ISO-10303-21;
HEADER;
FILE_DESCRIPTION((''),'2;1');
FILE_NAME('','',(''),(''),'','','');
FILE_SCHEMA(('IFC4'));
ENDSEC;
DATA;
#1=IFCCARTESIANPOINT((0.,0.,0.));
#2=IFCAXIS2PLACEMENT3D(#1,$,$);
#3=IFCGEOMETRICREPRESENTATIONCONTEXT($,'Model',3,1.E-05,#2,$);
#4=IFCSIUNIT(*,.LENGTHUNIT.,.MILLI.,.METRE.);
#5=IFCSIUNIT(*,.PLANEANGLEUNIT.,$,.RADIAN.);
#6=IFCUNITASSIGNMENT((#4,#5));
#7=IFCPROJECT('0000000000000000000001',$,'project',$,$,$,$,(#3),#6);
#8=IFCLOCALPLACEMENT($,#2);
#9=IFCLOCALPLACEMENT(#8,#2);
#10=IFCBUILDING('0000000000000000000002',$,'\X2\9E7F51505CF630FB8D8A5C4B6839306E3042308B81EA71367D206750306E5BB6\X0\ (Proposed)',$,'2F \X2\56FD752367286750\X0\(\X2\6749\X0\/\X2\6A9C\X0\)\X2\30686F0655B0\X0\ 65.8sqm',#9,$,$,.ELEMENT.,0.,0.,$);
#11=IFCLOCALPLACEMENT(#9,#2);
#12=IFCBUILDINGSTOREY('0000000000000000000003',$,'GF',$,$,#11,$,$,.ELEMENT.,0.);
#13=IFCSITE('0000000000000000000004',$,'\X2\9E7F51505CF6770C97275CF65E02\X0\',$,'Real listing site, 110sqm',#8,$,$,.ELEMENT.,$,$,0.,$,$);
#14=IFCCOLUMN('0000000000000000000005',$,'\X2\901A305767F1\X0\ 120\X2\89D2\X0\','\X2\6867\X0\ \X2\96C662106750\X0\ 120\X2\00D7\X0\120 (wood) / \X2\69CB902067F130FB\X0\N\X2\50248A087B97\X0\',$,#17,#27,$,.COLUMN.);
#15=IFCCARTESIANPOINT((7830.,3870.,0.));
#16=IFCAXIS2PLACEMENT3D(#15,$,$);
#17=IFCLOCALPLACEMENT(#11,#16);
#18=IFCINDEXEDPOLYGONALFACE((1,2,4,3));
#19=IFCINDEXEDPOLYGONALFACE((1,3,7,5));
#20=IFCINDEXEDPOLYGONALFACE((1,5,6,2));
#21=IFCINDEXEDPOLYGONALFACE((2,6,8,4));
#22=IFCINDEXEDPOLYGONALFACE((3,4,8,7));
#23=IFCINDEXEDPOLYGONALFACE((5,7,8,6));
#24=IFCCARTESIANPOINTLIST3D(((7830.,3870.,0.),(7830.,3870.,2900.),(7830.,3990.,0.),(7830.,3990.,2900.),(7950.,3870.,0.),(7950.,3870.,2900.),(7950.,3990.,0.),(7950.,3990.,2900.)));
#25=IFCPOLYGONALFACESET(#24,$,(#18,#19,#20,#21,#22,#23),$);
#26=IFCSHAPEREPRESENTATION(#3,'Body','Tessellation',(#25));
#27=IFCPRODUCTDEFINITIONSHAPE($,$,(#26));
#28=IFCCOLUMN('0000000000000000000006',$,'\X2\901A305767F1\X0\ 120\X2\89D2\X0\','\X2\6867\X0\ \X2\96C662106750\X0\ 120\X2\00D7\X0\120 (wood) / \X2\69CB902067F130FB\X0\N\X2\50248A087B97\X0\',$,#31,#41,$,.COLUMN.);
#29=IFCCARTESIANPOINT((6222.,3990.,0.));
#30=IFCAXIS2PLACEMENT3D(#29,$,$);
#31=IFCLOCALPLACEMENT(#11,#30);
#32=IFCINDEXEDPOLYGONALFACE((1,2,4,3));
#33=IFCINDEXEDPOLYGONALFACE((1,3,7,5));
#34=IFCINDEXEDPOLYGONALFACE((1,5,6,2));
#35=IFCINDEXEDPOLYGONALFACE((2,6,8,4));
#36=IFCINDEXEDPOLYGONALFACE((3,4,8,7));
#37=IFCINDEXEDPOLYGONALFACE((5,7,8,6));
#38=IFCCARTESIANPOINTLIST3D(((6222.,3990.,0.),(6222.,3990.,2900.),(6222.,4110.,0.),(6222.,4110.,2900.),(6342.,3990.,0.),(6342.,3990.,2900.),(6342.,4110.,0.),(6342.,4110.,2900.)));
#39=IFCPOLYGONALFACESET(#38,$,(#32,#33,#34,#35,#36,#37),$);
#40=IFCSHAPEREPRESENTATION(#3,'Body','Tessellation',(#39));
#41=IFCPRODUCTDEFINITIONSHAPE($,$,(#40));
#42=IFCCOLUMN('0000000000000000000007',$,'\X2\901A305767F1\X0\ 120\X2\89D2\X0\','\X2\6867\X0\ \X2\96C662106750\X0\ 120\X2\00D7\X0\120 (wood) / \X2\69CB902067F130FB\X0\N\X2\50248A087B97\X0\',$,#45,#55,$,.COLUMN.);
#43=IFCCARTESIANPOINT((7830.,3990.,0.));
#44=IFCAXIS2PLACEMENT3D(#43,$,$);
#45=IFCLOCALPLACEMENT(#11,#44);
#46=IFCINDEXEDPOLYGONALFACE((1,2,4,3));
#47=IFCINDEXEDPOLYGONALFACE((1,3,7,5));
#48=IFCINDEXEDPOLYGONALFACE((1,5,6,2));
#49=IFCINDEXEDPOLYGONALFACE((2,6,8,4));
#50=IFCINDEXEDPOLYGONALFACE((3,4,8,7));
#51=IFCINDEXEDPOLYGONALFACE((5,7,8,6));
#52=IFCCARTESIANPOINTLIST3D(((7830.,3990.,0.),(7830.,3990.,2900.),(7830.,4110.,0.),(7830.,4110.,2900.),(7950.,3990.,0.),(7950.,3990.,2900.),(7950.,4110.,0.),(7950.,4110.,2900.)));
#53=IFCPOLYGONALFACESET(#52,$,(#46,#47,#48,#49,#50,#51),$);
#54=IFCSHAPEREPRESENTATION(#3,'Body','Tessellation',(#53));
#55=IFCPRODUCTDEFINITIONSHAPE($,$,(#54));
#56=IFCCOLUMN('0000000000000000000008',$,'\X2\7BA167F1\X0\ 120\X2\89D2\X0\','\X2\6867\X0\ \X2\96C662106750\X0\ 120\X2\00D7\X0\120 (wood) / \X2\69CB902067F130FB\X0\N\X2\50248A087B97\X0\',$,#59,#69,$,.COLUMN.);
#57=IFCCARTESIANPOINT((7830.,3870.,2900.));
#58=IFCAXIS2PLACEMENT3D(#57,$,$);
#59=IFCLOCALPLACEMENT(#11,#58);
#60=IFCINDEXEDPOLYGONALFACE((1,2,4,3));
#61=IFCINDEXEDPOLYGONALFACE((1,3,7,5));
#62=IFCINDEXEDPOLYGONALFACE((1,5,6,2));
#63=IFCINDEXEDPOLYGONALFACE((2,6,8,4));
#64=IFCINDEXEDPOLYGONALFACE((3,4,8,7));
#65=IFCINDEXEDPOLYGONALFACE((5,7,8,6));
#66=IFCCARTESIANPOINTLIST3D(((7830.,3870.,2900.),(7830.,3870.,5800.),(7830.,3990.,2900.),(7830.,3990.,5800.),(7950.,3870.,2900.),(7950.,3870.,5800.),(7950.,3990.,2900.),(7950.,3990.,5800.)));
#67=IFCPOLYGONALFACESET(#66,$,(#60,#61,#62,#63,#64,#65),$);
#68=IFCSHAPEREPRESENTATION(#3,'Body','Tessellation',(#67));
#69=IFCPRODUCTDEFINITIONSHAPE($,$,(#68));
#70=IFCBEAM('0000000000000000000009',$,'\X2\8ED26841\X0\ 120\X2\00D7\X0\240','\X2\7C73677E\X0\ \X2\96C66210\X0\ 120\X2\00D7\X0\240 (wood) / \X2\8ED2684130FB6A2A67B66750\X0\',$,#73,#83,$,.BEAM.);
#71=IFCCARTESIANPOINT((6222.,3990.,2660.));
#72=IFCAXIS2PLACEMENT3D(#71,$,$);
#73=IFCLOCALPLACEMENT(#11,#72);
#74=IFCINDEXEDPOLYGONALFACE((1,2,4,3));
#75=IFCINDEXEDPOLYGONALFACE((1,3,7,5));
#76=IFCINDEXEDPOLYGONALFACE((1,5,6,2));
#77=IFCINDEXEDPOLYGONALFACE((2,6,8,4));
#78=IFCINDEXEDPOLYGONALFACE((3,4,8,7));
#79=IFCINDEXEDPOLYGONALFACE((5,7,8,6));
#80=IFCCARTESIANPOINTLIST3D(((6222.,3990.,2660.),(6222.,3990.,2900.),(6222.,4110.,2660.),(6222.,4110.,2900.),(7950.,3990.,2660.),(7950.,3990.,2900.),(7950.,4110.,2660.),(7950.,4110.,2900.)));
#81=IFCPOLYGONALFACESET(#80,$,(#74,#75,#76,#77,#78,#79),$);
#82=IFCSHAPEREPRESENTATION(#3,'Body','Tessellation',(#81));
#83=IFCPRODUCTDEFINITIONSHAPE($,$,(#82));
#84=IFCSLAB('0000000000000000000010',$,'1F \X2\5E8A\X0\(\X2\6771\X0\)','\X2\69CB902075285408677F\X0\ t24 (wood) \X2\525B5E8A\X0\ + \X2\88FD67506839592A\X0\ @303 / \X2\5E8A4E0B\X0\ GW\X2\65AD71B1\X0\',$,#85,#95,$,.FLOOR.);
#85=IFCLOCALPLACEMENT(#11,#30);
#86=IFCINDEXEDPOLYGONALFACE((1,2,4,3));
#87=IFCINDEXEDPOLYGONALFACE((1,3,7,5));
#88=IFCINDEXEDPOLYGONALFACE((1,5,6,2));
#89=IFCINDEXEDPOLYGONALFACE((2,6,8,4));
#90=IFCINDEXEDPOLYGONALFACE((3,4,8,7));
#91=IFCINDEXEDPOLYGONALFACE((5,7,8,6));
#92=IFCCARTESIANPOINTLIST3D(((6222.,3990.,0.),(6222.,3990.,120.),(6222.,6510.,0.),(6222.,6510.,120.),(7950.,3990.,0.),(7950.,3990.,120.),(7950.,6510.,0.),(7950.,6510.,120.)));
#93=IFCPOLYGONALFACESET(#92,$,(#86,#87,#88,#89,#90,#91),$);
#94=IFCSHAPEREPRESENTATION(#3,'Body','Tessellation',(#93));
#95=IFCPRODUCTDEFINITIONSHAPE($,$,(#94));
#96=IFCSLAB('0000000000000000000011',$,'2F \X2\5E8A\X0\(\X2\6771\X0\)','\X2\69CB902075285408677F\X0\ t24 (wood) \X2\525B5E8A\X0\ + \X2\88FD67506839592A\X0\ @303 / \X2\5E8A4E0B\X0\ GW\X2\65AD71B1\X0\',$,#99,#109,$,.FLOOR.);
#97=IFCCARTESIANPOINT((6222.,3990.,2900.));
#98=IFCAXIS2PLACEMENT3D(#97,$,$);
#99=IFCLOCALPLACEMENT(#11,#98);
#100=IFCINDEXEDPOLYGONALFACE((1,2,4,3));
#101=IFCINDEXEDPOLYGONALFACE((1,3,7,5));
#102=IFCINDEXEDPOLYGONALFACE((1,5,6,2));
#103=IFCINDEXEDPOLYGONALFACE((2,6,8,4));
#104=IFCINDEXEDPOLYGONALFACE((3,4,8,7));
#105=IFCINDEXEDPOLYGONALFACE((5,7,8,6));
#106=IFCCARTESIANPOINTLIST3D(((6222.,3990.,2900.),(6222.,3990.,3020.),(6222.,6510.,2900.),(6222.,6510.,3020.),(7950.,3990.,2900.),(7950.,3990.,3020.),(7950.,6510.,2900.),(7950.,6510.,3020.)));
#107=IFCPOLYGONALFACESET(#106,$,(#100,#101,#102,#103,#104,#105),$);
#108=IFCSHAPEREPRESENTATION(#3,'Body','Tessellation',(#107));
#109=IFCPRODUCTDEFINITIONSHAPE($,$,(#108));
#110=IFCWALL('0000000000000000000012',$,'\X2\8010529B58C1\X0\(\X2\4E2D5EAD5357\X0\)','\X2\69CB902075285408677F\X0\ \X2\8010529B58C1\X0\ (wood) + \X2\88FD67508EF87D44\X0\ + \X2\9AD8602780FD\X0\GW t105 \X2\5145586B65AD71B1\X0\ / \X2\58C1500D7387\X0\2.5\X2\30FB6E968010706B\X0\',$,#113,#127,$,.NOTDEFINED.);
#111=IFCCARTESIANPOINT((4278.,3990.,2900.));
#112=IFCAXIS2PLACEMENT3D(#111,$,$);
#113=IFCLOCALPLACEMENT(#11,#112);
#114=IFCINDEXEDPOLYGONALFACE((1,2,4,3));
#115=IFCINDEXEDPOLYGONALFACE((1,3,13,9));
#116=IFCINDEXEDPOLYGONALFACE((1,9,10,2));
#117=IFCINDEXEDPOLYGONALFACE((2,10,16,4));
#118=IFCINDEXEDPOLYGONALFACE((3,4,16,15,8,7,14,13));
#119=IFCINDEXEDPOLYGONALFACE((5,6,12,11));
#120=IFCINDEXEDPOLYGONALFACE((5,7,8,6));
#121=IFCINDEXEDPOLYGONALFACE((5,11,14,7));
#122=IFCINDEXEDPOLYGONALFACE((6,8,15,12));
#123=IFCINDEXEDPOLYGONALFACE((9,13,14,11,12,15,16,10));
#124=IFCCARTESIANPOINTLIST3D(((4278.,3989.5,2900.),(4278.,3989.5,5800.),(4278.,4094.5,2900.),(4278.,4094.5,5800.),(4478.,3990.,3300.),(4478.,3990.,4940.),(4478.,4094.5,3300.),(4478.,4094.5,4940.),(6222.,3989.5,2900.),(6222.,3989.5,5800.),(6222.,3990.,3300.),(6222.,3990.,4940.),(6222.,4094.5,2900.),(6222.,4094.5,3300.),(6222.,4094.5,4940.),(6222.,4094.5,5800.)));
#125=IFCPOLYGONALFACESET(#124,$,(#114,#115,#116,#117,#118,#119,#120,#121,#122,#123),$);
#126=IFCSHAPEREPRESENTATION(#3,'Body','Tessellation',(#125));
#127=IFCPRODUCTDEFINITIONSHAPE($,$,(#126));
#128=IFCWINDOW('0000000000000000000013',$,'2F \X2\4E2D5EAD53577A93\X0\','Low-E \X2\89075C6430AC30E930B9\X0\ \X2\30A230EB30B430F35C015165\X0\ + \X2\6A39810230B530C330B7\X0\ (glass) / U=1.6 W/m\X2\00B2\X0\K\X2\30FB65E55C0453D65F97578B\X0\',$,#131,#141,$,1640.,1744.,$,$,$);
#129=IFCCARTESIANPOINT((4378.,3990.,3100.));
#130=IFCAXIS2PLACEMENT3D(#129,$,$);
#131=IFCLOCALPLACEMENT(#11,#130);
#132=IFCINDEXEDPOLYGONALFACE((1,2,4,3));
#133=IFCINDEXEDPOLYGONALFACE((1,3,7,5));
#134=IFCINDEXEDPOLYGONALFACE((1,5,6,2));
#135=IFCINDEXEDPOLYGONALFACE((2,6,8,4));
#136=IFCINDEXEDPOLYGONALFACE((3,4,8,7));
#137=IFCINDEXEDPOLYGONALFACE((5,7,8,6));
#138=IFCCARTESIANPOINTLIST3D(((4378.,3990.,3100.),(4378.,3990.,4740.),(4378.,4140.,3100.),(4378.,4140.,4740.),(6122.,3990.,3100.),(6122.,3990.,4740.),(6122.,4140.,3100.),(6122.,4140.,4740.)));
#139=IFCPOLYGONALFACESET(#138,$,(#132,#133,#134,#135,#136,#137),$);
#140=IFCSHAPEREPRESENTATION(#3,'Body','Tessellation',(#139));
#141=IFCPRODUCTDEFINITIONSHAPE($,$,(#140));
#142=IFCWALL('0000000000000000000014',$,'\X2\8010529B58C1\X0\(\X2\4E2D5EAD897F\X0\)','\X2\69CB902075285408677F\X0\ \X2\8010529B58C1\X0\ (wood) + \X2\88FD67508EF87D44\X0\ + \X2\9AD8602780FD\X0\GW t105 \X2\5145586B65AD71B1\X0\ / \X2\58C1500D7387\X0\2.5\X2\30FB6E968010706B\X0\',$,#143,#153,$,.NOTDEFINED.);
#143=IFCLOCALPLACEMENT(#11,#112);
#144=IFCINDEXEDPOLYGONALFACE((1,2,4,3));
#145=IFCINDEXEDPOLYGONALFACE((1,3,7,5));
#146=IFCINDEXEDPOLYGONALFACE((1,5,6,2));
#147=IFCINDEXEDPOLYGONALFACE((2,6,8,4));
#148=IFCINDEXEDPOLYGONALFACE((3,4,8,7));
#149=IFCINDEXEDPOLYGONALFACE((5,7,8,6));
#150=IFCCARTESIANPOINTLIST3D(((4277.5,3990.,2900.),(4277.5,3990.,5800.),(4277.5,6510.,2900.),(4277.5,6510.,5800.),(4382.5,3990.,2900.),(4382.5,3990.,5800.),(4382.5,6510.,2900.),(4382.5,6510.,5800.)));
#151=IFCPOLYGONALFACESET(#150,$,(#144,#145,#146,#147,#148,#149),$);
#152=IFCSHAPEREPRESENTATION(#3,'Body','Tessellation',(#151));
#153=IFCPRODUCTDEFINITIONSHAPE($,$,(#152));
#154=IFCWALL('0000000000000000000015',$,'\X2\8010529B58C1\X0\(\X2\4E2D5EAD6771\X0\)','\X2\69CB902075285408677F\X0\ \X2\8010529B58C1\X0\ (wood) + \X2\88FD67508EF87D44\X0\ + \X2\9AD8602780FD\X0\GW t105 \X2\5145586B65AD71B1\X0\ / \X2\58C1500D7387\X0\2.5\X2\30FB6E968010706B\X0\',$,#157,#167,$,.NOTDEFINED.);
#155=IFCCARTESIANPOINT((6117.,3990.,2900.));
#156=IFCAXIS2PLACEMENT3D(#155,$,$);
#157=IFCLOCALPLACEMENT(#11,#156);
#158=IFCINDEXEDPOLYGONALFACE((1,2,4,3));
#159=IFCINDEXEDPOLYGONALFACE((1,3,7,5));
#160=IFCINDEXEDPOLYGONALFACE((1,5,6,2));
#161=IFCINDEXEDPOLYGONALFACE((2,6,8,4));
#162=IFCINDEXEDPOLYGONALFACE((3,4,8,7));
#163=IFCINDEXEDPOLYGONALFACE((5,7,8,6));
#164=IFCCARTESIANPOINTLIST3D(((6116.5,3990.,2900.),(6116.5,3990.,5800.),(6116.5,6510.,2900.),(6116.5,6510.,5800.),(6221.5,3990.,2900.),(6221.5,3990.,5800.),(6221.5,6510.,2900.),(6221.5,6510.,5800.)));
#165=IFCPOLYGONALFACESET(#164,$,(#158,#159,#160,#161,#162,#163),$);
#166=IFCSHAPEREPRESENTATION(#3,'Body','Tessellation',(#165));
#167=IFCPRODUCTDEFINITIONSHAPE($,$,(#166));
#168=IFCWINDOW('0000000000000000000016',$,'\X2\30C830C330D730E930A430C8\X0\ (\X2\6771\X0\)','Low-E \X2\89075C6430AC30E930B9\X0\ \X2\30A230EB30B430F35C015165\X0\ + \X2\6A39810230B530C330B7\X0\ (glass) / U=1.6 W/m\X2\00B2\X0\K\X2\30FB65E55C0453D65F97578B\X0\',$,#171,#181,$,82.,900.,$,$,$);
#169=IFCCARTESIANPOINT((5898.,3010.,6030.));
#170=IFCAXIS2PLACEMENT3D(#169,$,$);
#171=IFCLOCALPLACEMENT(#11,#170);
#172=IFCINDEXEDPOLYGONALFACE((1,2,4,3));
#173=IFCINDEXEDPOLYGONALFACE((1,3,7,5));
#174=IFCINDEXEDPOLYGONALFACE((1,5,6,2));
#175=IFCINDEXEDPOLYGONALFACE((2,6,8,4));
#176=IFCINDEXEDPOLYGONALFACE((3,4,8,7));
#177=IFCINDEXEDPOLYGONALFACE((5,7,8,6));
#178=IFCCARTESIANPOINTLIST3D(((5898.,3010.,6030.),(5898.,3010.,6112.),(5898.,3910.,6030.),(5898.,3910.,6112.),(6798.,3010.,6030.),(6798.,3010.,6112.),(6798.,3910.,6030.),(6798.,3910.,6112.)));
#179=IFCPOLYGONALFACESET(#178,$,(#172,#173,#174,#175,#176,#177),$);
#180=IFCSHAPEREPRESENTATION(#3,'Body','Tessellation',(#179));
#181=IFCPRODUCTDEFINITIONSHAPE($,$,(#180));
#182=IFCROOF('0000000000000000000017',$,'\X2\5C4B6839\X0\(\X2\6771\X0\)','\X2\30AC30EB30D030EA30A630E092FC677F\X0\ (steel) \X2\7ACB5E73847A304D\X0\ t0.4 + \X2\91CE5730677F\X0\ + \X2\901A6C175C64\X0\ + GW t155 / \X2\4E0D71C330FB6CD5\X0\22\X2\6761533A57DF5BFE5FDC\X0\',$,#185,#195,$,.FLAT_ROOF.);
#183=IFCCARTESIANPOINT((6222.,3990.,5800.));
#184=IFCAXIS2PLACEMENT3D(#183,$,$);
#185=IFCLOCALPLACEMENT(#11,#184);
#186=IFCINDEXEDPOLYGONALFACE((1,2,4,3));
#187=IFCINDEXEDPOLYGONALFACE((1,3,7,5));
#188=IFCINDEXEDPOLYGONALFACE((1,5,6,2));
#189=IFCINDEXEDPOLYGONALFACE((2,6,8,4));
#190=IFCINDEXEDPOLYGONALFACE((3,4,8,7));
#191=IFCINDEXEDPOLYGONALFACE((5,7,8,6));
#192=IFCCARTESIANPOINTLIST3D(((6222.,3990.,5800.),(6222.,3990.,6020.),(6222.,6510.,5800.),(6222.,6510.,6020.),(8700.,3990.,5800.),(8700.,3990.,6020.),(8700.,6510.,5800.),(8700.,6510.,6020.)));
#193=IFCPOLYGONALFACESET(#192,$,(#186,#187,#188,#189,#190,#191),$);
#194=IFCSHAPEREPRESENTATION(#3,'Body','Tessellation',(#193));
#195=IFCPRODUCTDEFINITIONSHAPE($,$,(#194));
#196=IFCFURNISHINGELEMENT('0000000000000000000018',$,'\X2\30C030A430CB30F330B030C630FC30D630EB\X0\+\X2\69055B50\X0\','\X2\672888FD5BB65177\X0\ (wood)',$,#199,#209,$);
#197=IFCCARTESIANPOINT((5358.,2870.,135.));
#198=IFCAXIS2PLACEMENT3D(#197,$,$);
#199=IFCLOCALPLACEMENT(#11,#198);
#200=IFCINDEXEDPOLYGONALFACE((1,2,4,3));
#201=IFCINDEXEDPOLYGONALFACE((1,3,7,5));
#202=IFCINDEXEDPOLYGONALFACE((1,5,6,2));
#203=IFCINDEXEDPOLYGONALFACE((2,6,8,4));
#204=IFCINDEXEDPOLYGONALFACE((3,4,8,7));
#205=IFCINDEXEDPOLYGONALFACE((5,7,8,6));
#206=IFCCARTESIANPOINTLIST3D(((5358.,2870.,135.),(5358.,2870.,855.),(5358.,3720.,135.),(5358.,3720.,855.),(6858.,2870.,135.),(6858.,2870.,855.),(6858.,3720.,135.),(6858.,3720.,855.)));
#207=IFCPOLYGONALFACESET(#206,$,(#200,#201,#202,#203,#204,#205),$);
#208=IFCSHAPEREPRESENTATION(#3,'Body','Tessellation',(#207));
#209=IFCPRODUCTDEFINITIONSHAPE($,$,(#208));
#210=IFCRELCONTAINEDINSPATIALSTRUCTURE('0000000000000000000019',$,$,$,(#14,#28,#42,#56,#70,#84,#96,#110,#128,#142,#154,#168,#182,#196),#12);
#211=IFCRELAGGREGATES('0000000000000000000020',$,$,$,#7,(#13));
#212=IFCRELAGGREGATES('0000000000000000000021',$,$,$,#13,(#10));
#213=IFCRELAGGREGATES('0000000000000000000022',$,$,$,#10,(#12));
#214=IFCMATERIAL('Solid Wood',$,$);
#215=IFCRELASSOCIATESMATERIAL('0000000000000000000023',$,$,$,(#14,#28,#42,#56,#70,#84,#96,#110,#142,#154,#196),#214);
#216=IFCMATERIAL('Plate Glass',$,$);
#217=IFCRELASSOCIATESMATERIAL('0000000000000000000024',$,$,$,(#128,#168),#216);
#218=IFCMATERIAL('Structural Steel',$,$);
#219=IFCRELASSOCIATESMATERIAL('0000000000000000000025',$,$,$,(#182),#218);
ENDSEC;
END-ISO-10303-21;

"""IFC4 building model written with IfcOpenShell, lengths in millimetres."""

from ifc_helpers import new_model, si_unit, frame, frame_2d, origin, place, context, project, spatial, rectangle, extrude, material, element, fill, save


model = new_model("IFC4")

# Units and contexts
model_context = context("Model", 3, precision=1e-05, world=origin())
ifc_project = project(units=[si_unit("LENGTHUNIT", "METRE", prefix="MILLI"), si_unit("PLANEANGLEUNIT", "RADIAN")], contexts=[model_context])

# Site, building, storey
site_placement = place(None, origin())
site = spatial("IfcSite", under=ifc_project, at=site_placement, Name="鹿児島県霧島市", ObjectType="Real listing site, 110sqm", CompositionType="ELEMENT", RefElevation=0.0)
building_placement = place(site_placement, origin())
building = spatial("IfcBuilding", under=site, at=building_placement, Name="鹿児島・越屋根のある自然素材の家 (Proposed)", ObjectType="2F 国産木材(杉/檜)と漆喰 65.8sqm", CompositionType="ELEMENT", ElevationOfRefHeight=0.0, ElevationOfTerrain=0.0)
storey_placement = place(building_placement, origin())
storey = spatial("IfcBuildingStorey", under=building, at=storey_placement, Name="GF", CompositionType="ELEMENT", Elevation=0.0)

# Columns
ifc_material_1 = material(Name="Solid Wood")
column_1_placement = place(storey_placement, frame((7830.0, 3870.0, 0.0)))
element("IfcColumn", 1, at=column_1_placement, inside=storey, material=ifc_material_1, Name="通し柱 120角", Description="桧 集成材 120×120 (wood) / 構造柱・N値計算", PredefinedType="COLUMN", context=model_context, shape_type="SweptSolid", body=[
    extrude(rectangle(XDim=120.0, YDim=120.0, at=frame_2d((60.0, 60.0))), frame((7830.0, 3870.0, 0.0)), (0.0, 0.0, 1.0), 2900.0),
])
column_2_placement = place(storey_placement, frame((6222.0, 3990.0, 0.0)))
element("IfcColumn", 2, at=column_2_placement, inside=storey, material=ifc_material_1, Name="通し柱 120角", Description="桧 集成材 120×120 (wood) / 構造柱・N値計算", PredefinedType="COLUMN", context=model_context, shape_type="SweptSolid", body=[
    extrude(rectangle(XDim=120.0, YDim=120.0, at=frame_2d((60.0, 60.0))), frame((6222.0, 3990.0, 0.0)), (0.0, 0.0, 1.0), 2900.0),
])
column_3_placement = place(storey_placement, frame((7830.0, 3990.0, 0.0)))
element("IfcColumn", 3, at=column_3_placement, inside=storey, material=ifc_material_1, Name="通し柱 120角", Description="桧 集成材 120×120 (wood) / 構造柱・N値計算", PredefinedType="COLUMN", context=model_context, shape_type="SweptSolid", body=[
    extrude(rectangle(XDim=120.0, YDim=120.0, at=frame_2d((60.0, 60.0))), frame((7830.0, 3990.0, 0.0)), (0.0, 0.0, 1.0), 2900.0),
])
column_4_placement = place(storey_placement, frame((7830.0, 3870.0, 2900.0)))
element("IfcColumn", 4, at=column_4_placement, inside=storey, material=ifc_material_1, Name="管柱 120角", Description="桧 集成材 120×120 (wood) / 構造柱・N値計算", PredefinedType="COLUMN", context=model_context, shape_type="SweptSolid", body=[
    extrude(rectangle(XDim=120.0, YDim=120.0, at=frame_2d((60.0, 60.0))), frame((7830.0, 3870.0, 2900.0)), (0.0, 0.0, 1.0), 2900.0),
])

# Beam
beam_1_placement = place(storey_placement, frame((6222.0, 3990.0, 2660.0)))
element("IfcBeam", 5, at=beam_1_placement, inside=storey, material=ifc_material_1, Name="軒桁 120×240", Description="米松 集成 120×240 (wood) / 軒桁・横架材", PredefinedType="BEAM", context=model_context, shape_type="SweptSolid", body=[
    extrude(rectangle(XDim=1728.0, YDim=120.0, at=frame_2d((864.0, 60.0))), frame((6222.0, 3990.0, 2660.0)), (0.0, 0.0, 1.0), 240.0),
])

# Slabs
slab_1_placement = place(storey_placement, frame((6222.0, 3990.0, 0.0)))
element("IfcSlab", 6, at=slab_1_placement, inside=storey, material=ifc_material_1, Name="1F 床(東)", Description="構造用合板 t24 (wood) 剛床 + 製材根太 @303 / 床下 GW断熱", PredefinedType="FLOOR", context=model_context, shape_type="SweptSolid", body=[
    extrude(rectangle(XDim=1728.0, YDim=2520.0, at=frame_2d((864.0, 1260.0))), frame((6222.0, 3990.0, 0.0)), (0.0, 0.0, 1.0), 120.0),
])
slab_2_placement = place(storey_placement, frame((6222.0, 3990.0, 2900.0)))
element("IfcSlab", 7, at=slab_2_placement, inside=storey, material=ifc_material_1, Name="2F 床(東)", Description="構造用合板 t24 (wood) 剛床 + 製材根太 @303 / 床下 GW断熱", PredefinedType="FLOOR", context=model_context, shape_type="SweptSolid", body=[
    extrude(rectangle(XDim=1728.0, YDim=2520.0, at=frame_2d((864.0, 1260.0))), frame((6222.0, 3990.0, 2900.0)), (0.0, 0.0, 1.0), 120.0),
])

# Wall, opening, window
wall_1_placement = place(storey_placement, frame((4278.0, 3990.0, 2900.0)))
wall_1 = element("IfcWall", 8, at=wall_1_placement, inside=storey, material=ifc_material_1, Name="耐力壁(中庭南)", Description="構造用合板 耐力壁 (wood) + 製材軸組 + 高性能GW t105 充填断熱 / 壁倍率2.5・準耐火", PredefinedType="NOTDEFINED", context=model_context, shape_type="SweptSolid", body=[
    extrude(rectangle(XDim=1944.0, YDim=105.0, at=frame_2d((972.0, 52.0))), frame((4278.0, 3990.0, 2900.0)), (0.0, 0.0, 1.0), 2900.0),
])
opening_placement = place(storey_placement, frame((4378.0, 3990.0, 3100.0)))
opening = element("IfcOpeningElement", 9, at=opening_placement, cuts=wall_1, PredefinedType="NOTDEFINED", context=model_context, shape_type="SweptSolid", body=[
    extrude(rectangle(XDim=1744.0, YDim=150.0, at=frame_2d((872.0, 75.0))), frame((4378.0, 3990.0, 3100.0)), (0.0, 0.0, 1.0), 1640.0),
])
ifc_material_2 = material(Name="Plate Glass")
window_1_placement = place(storey_placement, frame((4378.0, 3990.0, 3100.0)))
window_1 = element("IfcWindow", 10, at=window_1_placement, inside=storey, material=ifc_material_2, Name="2F 中庭南窓", Description="Low-E 複層ガラス アルゴン封入 + 樹脂サッシ (glass) / U=1.6 W/m²K・日射取得型", OverallHeight=1640.0, OverallWidth=1744.0, context=model_context, shape_type="SweptSolid", body=[
    extrude(rectangle(XDim=1744.0, YDim=150.0, at=frame_2d((872.0, 75.0))), frame((4378.0, 3990.0, 3100.0)), (0.0, 0.0, 1.0), 1640.0),
])
fill(opening, window_1)

# Walls
wall_2_placement = place(storey_placement, frame((4278.0, 3990.0, 2900.0)))
element("IfcWall", 11, at=wall_2_placement, inside=storey, material=ifc_material_1, Name="耐力壁(中庭西)", Description="構造用合板 耐力壁 (wood) + 製材軸組 + 高性能GW t105 充填断熱 / 壁倍率2.5・準耐火", PredefinedType="NOTDEFINED", context=model_context, shape_type="SweptSolid", body=[
    extrude(rectangle(XDim=105.0, YDim=2520.0, at=frame_2d((52.0, 1260.0))), frame((4278.0, 3990.0, 2900.0)), (0.0, 0.0, 1.0), 2900.0),
])
wall_3_placement = place(storey_placement, frame((6117.0, 3990.0, 2900.0)))
element("IfcWall", 12, at=wall_3_placement, inside=storey, material=ifc_material_1, Name="耐力壁(中庭東)", Description="構造用合板 耐力壁 (wood) + 製材軸組 + 高性能GW t105 充填断熱 / 壁倍率2.5・準耐火", PredefinedType="NOTDEFINED", context=model_context, shape_type="SweptSolid", body=[
    extrude(rectangle(XDim=105.0, YDim=2520.0, at=frame_2d((52.0, 1260.0))), frame((6117.0, 3990.0, 2900.0)), (0.0, 0.0, 1.0), 2900.0),
])

# Window
window_2_placement = place(storey_placement, frame((5898.0, 3010.0, 6030.0)))
element("IfcWindow", 13, at=window_2_placement, inside=storey, material=ifc_material_2, Name="トップライト (東)", Description="Low-E 複層ガラス アルゴン封入 + 樹脂サッシ (glass) / U=1.6 W/m²K・日射取得型", OverallHeight=82.0, OverallWidth=900.0, context=model_context, shape_type="SweptSolid", body=[
    extrude(rectangle(XDim=900.0, YDim=900.0, at=frame_2d((450.0, 450.0))), frame((5898.0, 3010.0, 6030.0)), (0.0, 0.0, 1.0), 82.0),
])

# Roof
ifc_material_3 = material(Name="Structural Steel")
for number, where, name in (
    (14, (6222.0, 3990.0, 5800.0), "屋根(東)"),
):
    element("IfcRoof", number, at=place(storey_placement, frame(where)), inside=storey, material=ifc_material_3, Name=name, Description="ガルバリウム鋼板 (steel) 立平葺き t0.4 + 野地板 + 通気層 + GW t155 / 不燃・法22条区域対応", PredefinedType="FLAT_ROOF", context=model_context, shape_type="SweptSolid", body=[
        extrude(rectangle(XDim=2478.0, YDim=2520.0, at=frame_2d((1239.0, 1260.0))), frame((6222.0, 3990.0, 5800.0)), (0.0, 0.0, 1.0), 220.0),
    ])

# Furnishing element
furnishing_1_placement = place(storey_placement, frame((5358.0, 2870.0, 135.0)))
element("IfcFurnishingElement", 15, at=furnishing_1_placement, inside=storey, material=ifc_material_1, Name="ダイニングテーブル+椅子", Description="木製家具 (wood)", context=model_context, shape_type="SweptSolid", body=[
    extrude(rectangle(XDim=1500.0, YDim=850.0, at=frame_2d((750.0, 425.0))), frame((5358.0, 2870.0, 135.0)), (0.0, 0.0, 1.0), 720.0),
])

save(model, "model.ifc")
